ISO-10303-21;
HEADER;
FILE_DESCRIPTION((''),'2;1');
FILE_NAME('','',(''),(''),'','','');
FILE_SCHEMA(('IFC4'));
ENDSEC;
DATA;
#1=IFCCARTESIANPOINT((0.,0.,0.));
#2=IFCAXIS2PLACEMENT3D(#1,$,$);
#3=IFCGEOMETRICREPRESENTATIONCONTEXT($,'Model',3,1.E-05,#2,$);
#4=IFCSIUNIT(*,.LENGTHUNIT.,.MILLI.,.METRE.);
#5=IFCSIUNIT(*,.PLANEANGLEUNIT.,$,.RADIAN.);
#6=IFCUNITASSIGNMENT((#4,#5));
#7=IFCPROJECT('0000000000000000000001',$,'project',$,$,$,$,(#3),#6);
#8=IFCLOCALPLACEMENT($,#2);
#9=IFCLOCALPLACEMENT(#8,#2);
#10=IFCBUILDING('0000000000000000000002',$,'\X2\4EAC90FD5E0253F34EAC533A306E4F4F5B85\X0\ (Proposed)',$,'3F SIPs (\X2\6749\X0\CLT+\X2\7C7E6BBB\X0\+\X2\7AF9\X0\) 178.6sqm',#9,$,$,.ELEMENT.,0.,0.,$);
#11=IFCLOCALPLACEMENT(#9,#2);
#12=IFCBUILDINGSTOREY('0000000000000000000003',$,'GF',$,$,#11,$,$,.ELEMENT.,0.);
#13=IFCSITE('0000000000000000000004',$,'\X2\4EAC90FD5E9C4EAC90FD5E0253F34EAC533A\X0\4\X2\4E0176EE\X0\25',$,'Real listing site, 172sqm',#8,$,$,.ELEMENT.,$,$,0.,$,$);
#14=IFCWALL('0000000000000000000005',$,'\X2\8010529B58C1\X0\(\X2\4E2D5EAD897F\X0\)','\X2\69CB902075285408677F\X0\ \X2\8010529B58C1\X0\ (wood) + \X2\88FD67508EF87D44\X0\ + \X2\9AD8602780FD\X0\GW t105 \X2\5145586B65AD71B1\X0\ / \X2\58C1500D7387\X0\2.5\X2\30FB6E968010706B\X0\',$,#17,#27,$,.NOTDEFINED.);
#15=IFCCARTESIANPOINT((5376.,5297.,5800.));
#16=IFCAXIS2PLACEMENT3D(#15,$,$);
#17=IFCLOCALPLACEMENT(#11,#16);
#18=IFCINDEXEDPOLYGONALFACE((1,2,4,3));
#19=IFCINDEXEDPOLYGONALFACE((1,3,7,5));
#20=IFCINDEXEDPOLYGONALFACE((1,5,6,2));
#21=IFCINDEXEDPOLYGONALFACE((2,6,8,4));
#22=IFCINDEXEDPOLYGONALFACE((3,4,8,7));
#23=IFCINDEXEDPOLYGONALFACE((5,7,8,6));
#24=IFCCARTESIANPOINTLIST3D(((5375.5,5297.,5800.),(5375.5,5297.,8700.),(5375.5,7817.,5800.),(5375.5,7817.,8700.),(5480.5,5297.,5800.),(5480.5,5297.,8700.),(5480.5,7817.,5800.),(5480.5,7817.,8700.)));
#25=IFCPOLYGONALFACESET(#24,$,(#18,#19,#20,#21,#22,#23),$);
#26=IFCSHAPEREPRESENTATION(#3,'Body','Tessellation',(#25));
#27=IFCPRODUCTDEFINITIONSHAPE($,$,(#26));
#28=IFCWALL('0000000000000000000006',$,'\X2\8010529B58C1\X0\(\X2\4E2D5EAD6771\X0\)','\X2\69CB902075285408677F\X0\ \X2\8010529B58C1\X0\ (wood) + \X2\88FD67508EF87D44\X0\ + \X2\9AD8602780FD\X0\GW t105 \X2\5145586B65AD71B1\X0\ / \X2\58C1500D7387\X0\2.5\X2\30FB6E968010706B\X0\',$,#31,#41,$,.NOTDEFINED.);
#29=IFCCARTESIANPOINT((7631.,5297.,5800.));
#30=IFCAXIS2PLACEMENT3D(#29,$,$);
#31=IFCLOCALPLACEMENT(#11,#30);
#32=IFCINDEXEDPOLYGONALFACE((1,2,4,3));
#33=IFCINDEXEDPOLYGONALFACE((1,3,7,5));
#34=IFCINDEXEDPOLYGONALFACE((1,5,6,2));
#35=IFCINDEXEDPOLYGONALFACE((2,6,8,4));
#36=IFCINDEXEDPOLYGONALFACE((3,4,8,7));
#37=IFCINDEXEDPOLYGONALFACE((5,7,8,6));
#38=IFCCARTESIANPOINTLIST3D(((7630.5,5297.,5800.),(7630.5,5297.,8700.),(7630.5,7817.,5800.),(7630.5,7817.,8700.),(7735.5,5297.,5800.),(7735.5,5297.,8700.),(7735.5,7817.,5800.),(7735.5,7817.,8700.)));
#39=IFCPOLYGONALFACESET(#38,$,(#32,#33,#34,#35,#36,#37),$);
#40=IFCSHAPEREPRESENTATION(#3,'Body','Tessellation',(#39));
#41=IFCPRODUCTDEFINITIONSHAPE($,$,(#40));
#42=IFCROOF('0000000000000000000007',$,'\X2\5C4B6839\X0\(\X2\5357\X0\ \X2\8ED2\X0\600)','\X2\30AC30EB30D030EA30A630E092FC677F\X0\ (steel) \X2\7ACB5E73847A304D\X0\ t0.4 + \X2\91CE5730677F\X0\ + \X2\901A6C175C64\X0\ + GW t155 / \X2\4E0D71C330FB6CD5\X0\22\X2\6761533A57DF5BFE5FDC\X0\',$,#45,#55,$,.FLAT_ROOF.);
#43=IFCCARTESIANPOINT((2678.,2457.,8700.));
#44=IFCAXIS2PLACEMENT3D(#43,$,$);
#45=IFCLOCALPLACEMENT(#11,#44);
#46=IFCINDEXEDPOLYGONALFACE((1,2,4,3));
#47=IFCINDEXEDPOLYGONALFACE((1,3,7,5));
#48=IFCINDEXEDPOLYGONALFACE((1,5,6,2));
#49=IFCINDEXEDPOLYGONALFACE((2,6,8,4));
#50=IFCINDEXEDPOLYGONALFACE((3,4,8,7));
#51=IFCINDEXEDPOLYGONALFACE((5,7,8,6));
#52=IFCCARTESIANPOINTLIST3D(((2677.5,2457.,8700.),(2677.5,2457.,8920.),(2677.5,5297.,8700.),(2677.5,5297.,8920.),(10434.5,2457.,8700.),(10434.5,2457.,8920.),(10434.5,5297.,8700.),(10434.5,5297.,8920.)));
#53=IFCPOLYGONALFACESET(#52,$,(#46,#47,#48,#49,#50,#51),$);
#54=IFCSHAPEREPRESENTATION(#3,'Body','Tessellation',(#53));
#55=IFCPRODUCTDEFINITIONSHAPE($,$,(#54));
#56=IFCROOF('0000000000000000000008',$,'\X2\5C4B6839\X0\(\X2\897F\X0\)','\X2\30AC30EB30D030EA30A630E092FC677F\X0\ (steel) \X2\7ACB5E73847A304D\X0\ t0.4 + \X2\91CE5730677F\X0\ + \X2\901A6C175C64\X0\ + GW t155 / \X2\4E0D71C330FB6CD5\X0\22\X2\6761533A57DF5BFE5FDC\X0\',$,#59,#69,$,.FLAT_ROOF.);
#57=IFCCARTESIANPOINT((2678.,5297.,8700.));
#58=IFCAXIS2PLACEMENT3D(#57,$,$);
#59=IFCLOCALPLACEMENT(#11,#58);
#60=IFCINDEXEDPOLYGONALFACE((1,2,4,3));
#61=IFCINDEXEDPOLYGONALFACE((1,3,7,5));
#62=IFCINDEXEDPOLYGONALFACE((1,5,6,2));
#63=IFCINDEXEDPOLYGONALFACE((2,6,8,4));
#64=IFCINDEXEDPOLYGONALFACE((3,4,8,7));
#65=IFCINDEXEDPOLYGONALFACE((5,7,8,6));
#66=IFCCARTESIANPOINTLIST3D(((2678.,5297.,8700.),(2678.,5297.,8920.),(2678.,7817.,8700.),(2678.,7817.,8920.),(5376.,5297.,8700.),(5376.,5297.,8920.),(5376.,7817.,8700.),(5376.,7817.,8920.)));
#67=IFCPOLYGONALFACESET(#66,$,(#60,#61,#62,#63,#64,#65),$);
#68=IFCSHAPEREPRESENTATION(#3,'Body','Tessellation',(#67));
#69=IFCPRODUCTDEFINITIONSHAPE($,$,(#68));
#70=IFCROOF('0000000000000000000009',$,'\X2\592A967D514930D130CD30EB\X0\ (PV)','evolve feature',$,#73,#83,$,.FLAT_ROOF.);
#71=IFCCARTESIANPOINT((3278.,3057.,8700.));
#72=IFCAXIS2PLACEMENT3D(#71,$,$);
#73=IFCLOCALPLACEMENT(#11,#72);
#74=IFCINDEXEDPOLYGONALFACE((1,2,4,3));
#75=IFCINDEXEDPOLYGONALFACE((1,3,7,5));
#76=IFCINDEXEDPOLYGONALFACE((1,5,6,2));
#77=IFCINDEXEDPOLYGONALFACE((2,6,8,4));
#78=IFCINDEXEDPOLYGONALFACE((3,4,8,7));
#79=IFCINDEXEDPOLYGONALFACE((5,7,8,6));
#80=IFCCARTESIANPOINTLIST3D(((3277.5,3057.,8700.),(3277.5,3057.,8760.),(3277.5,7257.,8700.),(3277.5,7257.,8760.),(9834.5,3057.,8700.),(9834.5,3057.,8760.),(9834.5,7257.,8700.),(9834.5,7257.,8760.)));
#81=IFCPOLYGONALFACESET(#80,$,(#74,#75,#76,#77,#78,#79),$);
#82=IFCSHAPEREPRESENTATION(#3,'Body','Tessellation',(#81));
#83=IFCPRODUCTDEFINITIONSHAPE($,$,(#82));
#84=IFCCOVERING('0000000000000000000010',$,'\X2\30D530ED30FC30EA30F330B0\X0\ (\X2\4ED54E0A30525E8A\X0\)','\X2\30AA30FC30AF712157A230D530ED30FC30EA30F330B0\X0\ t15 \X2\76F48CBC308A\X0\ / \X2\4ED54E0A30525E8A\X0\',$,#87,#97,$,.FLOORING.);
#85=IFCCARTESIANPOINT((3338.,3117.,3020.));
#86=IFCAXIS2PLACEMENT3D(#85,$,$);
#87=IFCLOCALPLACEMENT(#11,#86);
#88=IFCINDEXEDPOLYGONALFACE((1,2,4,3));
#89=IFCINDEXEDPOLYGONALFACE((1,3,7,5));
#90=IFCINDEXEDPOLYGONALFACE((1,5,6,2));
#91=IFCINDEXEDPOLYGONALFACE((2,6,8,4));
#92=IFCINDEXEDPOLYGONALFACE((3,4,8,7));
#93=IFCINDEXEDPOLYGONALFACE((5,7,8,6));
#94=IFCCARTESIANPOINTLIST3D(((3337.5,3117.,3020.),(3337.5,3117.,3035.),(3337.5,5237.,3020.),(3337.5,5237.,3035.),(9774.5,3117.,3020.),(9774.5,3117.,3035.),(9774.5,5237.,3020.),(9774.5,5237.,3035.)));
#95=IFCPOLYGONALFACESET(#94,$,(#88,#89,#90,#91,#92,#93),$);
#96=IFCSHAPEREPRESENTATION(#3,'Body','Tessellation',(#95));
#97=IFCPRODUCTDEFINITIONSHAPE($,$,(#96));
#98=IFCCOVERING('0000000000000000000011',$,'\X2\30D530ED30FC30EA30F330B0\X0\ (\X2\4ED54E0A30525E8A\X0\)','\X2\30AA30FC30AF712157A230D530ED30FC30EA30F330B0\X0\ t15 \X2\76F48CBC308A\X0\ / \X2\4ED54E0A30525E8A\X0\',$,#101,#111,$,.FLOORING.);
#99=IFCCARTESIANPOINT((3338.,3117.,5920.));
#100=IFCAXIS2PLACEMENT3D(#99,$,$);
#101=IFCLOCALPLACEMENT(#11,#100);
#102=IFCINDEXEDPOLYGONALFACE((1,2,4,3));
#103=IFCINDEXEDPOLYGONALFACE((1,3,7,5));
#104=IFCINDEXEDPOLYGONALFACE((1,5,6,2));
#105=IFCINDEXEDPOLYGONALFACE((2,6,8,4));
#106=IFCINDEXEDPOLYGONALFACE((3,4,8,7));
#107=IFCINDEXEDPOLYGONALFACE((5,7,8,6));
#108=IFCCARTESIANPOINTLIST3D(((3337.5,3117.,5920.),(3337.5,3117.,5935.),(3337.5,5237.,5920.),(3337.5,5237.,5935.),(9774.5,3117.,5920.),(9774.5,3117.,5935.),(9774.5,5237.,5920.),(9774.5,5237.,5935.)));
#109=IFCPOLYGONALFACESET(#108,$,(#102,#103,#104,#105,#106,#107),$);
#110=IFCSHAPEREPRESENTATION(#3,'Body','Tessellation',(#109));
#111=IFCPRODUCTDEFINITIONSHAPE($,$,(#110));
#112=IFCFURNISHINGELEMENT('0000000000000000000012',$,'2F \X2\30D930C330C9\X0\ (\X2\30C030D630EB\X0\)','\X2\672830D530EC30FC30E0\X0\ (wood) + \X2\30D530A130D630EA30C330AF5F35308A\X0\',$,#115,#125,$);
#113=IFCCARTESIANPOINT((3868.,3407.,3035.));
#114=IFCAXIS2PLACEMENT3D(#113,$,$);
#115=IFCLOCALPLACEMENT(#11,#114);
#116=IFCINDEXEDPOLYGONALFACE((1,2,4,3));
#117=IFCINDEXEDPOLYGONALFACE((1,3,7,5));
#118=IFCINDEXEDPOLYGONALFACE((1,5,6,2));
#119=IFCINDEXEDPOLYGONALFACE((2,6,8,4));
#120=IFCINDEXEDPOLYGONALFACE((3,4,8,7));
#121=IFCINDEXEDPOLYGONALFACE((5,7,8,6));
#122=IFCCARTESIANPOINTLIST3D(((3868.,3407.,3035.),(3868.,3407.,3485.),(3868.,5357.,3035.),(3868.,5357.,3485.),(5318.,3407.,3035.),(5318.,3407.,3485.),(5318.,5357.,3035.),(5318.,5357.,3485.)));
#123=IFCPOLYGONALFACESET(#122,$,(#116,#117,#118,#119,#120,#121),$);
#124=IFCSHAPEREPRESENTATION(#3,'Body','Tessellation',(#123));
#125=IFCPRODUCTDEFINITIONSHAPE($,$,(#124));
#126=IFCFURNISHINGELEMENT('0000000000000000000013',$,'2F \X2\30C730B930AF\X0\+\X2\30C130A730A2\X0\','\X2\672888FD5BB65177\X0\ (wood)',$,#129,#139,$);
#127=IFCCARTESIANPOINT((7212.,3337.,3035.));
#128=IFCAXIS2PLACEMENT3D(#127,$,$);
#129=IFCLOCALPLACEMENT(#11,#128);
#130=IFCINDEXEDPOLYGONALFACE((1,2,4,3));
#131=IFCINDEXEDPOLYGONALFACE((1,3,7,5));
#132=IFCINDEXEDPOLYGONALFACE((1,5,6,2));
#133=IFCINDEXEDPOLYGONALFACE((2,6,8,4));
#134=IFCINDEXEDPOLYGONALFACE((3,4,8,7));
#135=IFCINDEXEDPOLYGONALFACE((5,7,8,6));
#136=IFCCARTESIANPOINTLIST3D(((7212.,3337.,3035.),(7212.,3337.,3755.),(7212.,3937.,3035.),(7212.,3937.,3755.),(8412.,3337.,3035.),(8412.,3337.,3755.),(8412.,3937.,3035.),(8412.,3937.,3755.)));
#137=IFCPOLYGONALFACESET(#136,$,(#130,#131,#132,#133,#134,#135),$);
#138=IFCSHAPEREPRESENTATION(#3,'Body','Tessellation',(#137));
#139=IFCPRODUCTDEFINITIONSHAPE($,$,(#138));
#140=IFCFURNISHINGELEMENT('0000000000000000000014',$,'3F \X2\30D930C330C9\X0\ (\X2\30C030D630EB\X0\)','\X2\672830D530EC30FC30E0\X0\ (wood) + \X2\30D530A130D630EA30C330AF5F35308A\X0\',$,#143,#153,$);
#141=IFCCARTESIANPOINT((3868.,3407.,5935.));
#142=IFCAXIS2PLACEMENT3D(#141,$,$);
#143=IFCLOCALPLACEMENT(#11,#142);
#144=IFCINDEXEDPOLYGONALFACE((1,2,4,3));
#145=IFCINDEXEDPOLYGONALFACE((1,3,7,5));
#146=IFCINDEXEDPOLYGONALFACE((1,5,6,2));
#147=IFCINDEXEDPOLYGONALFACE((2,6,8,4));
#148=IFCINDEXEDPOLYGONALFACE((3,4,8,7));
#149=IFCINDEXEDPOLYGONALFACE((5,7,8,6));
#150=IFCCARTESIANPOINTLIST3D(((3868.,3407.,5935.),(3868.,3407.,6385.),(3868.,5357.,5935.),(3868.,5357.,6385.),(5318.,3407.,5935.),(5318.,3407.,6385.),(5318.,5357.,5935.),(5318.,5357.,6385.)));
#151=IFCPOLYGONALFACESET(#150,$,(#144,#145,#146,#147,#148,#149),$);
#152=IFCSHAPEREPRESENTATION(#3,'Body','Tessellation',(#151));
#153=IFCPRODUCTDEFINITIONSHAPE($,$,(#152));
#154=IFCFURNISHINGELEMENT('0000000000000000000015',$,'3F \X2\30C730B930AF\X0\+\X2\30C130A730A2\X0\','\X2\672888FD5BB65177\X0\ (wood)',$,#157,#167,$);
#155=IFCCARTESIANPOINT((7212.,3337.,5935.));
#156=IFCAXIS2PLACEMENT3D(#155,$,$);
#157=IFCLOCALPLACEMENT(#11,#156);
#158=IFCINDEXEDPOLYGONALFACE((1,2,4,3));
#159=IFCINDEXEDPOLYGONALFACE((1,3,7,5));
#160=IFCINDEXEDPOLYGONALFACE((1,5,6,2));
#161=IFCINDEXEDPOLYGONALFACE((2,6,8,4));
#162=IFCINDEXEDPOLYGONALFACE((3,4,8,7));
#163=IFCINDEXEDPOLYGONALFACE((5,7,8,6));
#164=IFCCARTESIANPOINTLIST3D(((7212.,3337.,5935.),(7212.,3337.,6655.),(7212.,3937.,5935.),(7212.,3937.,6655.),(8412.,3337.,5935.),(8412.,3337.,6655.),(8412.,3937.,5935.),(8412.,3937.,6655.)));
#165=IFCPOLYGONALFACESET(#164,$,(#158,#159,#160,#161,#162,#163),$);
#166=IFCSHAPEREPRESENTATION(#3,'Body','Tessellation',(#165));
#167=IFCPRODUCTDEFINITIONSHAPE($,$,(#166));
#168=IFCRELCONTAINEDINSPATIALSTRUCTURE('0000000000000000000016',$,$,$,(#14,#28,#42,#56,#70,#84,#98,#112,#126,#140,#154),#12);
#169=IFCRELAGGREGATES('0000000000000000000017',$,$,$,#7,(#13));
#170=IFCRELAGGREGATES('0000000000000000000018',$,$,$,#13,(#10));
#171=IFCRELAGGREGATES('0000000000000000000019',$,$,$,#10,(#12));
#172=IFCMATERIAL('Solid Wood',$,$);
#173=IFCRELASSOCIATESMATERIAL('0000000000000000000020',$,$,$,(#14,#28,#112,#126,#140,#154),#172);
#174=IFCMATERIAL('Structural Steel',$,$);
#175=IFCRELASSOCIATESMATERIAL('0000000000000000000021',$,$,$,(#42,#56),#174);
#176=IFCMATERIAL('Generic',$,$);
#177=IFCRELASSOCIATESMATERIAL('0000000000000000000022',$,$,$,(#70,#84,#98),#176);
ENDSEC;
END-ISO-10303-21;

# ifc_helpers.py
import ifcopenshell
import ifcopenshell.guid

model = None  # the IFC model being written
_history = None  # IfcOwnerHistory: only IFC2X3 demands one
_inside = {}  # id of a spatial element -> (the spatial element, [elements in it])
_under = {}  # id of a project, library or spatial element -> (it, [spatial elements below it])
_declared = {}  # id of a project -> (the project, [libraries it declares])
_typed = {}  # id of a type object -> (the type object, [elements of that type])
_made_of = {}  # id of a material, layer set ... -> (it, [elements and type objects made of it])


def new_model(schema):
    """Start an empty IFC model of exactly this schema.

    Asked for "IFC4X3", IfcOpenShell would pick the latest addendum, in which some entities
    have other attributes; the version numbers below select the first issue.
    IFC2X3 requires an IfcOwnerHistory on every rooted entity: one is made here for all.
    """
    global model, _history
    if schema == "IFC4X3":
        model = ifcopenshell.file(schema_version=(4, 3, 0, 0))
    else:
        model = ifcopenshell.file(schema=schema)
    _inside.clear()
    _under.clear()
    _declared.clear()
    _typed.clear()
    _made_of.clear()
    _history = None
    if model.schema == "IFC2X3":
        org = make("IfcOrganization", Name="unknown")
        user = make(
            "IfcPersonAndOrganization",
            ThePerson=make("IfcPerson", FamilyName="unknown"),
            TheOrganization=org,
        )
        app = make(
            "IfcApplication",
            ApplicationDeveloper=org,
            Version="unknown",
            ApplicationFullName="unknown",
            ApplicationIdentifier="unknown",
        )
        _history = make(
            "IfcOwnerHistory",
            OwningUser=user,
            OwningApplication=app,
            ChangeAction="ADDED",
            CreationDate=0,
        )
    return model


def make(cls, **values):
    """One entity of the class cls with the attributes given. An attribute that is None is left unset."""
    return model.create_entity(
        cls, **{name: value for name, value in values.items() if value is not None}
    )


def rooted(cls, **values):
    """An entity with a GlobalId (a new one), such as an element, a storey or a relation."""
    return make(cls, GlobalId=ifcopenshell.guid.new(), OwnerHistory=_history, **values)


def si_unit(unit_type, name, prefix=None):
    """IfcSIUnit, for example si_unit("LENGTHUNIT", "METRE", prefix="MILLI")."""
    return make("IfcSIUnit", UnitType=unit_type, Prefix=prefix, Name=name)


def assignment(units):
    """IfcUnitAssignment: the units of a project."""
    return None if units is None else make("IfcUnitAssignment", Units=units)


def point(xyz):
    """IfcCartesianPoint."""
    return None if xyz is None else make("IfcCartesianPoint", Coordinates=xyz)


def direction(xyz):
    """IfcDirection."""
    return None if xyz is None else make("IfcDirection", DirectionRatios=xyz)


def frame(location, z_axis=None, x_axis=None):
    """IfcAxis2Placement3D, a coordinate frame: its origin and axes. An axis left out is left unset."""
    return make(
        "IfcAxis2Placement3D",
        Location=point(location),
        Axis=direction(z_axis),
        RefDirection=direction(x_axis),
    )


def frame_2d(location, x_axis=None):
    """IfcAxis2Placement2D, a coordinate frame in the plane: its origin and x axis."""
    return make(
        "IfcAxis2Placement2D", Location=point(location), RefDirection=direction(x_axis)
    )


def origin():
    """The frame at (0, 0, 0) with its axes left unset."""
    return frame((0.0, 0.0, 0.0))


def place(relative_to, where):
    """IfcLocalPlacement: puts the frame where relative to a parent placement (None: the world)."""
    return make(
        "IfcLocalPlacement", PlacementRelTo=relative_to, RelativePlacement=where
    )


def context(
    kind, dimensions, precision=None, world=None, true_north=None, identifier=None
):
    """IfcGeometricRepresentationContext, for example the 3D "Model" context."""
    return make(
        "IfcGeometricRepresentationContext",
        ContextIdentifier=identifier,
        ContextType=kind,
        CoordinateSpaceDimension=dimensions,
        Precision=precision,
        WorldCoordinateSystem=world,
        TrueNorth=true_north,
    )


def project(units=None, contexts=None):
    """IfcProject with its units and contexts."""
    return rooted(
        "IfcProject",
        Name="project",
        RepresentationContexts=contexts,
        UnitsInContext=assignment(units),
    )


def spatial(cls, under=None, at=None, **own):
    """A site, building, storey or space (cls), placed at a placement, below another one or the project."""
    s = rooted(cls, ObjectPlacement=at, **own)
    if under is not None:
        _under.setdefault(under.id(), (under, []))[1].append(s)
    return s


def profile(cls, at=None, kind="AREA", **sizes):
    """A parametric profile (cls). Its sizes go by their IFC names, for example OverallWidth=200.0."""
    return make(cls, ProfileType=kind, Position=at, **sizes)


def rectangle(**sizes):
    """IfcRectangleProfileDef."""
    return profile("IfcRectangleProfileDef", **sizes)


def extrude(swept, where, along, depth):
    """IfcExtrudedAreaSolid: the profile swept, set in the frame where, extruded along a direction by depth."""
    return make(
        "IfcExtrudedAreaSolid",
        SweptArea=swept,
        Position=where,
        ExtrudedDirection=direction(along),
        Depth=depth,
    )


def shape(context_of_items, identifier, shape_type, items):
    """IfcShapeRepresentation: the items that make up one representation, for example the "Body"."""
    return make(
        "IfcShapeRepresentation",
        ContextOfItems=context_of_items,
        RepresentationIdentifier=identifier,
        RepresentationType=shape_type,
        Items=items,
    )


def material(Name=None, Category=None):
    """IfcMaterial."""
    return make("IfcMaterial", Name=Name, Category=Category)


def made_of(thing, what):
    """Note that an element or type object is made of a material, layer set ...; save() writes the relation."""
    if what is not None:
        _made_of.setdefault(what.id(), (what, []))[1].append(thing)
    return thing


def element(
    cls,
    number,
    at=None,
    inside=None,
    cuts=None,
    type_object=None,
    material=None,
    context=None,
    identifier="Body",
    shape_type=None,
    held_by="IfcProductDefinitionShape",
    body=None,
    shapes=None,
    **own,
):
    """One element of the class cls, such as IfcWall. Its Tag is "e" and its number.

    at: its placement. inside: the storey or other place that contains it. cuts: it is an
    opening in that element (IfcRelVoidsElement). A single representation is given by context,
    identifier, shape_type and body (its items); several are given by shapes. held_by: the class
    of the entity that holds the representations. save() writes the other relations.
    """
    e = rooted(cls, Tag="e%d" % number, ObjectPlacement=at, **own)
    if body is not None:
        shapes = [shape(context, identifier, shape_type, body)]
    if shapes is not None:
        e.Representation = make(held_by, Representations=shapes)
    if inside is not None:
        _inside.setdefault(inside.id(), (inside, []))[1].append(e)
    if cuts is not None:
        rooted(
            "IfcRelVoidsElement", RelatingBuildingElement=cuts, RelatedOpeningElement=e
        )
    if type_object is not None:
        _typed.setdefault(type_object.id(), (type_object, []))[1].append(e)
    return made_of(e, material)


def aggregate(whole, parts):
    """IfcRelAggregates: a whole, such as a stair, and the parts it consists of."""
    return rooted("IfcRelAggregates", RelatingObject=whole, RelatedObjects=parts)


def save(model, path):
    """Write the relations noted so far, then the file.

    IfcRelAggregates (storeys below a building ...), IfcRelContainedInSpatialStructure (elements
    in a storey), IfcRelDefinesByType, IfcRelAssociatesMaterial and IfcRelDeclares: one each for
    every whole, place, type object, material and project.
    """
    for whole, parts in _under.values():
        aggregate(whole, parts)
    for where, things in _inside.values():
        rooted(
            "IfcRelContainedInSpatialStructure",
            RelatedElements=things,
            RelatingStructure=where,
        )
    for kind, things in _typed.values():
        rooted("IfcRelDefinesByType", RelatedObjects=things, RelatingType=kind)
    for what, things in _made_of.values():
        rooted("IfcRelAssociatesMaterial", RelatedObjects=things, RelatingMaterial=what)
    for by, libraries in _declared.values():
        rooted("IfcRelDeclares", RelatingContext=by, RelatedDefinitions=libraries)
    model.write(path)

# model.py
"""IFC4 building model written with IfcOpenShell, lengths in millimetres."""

from ifc_helpers import new_model, si_unit, frame, frame_2d, origin, place, context, project, spatial, rectangle, extrude, material, element, save


model = new_model("IFC4")

# Units and contexts
model_context = context("Model", 3, precision=1e-05, world=origin())
ifc_project = project(units=[si_unit("LENGTHUNIT", "METRE", prefix="MILLI"), si_unit("PLANEANGLEUNIT", "RADIAN")], contexts=[model_context])

# Site, building, storey
site_placement = place(None, origin())
site = spatial("IfcSite", under=ifc_project, at=site_placement, Name="京都府京都市右京区4丁目25", ObjectType="Real listing site, 172sqm", CompositionType="ELEMENT", RefElevation=0.0)
building_placement = place(site_placement, origin())
building = spatial("IfcBuilding", under=site, at=building_placement, Name="京都市右京区の住宅 (Proposed)", ObjectType="3F SIPs (杉CLT+籾殻+竹) 178.6sqm", CompositionType="ELEMENT", ElevationOfRefHeight=0.0, ElevationOfTerrain=0.0)
storey_placement = place(building_placement, origin())
storey = spatial("IfcBuildingStorey", under=building, at=storey_placement, Name="GF", CompositionType="ELEMENT", Elevation=0.0)

# Shared definitions
ifc_material_1 = material(Name="Solid Wood")

# Walls
wall_1_placement = place(storey_placement, frame((5376.0, 5297.0, 5800.0)))
element("IfcWall", 1, at=wall_1_placement, inside=storey, material=ifc_material_1, Name="耐力壁(中庭西)", Description="構造用合板 耐力壁 (wood) + 製材軸組 + 高性能GW t105 充填断熱 / 壁倍率2.5・準耐火", PredefinedType="NOTDEFINED", context=model_context, shape_type="SweptSolid", body=[
    extrude(rectangle(XDim=105.0, YDim=2520.0, at=frame_2d((52.0, 1260.0))), frame((5376.0, 5297.0, 5800.0)), (0.0, 0.0, 1.0), 2900.0),
])
wall_2_placement = place(storey_placement, frame((7631.0, 5297.0, 5800.0)))
element("IfcWall", 2, at=wall_2_placement, inside=storey, material=ifc_material_1, Name="耐力壁(中庭東)", Description="構造用合板 耐力壁 (wood) + 製材軸組 + 高性能GW t105 充填断熱 / 壁倍率2.5・準耐火", PredefinedType="NOTDEFINED", context=model_context, shape_type="SweptSolid", body=[
    extrude(rectangle(XDim=105.0, YDim=2520.0, at=frame_2d((52.0, 1260.0))), frame((7631.0, 5297.0, 5800.0)), (0.0, 0.0, 1.0), 2900.0),
])

# Roofs
ifc_material_2 = material(Name="Structural Steel")
roof_1_placement = place(storey_placement, frame((2678.0, 2457.0, 8700.0)))
element("IfcRoof", 3, at=roof_1_placement, inside=storey, material=ifc_material_2, Name="屋根(南 軒600)", Description="ガルバリウム鋼板 (steel) 立平葺き t0.4 + 野地板 + 通気層 + GW t155 / 不燃・法22条区域対応", PredefinedType="FLAT_ROOF", context=model_context, shape_type="SweptSolid", body=[
    extrude(rectangle(XDim=7757.0, YDim=2840.0, at=frame_2d((3878.0, 1420.0))), frame((2678.0, 2457.0, 8700.0)), (0.0, 0.0, 1.0), 220.0),
])
roof_2_placement = place(storey_placement, frame((2678.0, 5297.0, 8700.0)))
element("IfcRoof", 4, at=roof_2_placement, inside=storey, material=ifc_material_2, Name="屋根(西)", Description="ガルバリウム鋼板 (steel) 立平葺き t0.4 + 野地板 + 通気層 + GW t155 / 不燃・法22条区域対応", PredefinedType="FLAT_ROOF", context=model_context, shape_type="SweptSolid", body=[
    extrude(rectangle(XDim=2698.0, YDim=2520.0, at=frame_2d((1349.0, 1260.0))), frame((2678.0, 5297.0, 8700.0)), (0.0, 0.0, 1.0), 220.0),
])
ifc_material_3 = material(Name="Generic")
roof_3_placement = place(storey_placement, frame((3278.0, 3057.0, 8700.0)))
element("IfcRoof", 5, at=roof_3_placement, inside=storey, material=ifc_material_3, Name="太陽光パネル (PV)", Description="evolve feature", PredefinedType="FLAT_ROOF", context=model_context, shape_type="SweptSolid", body=[
    extrude(rectangle(XDim=6557.0, YDim=4200.0, at=frame_2d((3278.0, 2100.0))), frame((3278.0, 3057.0, 8700.0)), (0.0, 0.0, 1.0), 60.0),
])

# Coverings
covering_1_placement = place(storey_placement, frame((3338.0, 3117.0, 3020.0)))
element("IfcCovering", 6, at=covering_1_placement, inside=storey, material=ifc_material_3, Name="フローリング (仕上げ床)", Description="オーク無垢フローリング t15 直貼り / 仕上げ床", PredefinedType="FLOORING", context=model_context, shape_type="SweptSolid", body=[
    extrude(rectangle(XDim=6437.0, YDim=2120.0, at=frame_2d((3218.0, 1060.0))), frame((3338.0, 3117.0, 3020.0)), (0.0, 0.0, 1.0), 15.0),
])
covering_2_placement = place(storey_placement, frame((3338.0, 3117.0, 5920.0)))
element("IfcCovering", 7, at=covering_2_placement, inside=storey, material=ifc_material_3, Name="フローリング (仕上げ床)", Description="オーク無垢フローリング t15 直貼り / 仕上げ床", PredefinedType="FLOORING", context=model_context, shape_type="SweptSolid", body=[
    extrude(rectangle(XDim=6437.0, YDim=2120.0, at=frame_2d((3218.0, 1060.0))), frame((3338.0, 3117.0, 5920.0)), (0.0, 0.0, 1.0), 15.0),
])

# Furnishing elements
furnishing_1_placement = place(storey_placement, frame((3868.0, 3407.0, 3035.0)))
element("IfcFurnishingElement", 8, at=furnishing_1_placement, inside=storey, material=ifc_material_1, Name="2F ベッド (ダブル)", Description="木フレーム (wood) + ファブリック張り", context=model_context, shape_type="SweptSolid", body=[
    extrude(rectangle(XDim=1450.0, YDim=1950.0, at=frame_2d((725.0, 975.0))), frame((3868.0, 3407.0, 3035.0)), (0.0, 0.0, 1.0), 450.0),
])
furnishing_2_placement = place(storey_placement, frame((7212.0, 3337.0, 3035.0)))
element("IfcFurnishingElement", 9, at=furnishing_2_placement, inside=storey, material=ifc_material_1, Name="2F デスク+チェア", Description="木製家具 (wood)", context=model_context, shape_type="SweptSolid", body=[
    extrude(rectangle(XDim=1200.0, YDim=600.0, at=frame_2d((600.0, 300.0))), frame((7212.0, 3337.0, 3035.0)), (0.0, 0.0, 1.0), 720.0),
])
furnishing_3_placement = place(storey_placement, frame((3868.0, 3407.0, 5935.0)))
element("IfcFurnishingElement", 10, at=furnishing_3_placement, inside=storey, material=ifc_material_1, Name="3F ベッド (ダブル)", Description="木フレーム (wood) + ファブリック張り", context=model_context, shape_type="SweptSolid", body=[
    extrude(rectangle(XDim=1450.0, YDim=1950.0, at=frame_2d((725.0, 975.0))), frame((3868.0, 3407.0, 5935.0)), (0.0, 0.0, 1.0), 450.0),
])
furnishing_4_placement = place(storey_placement, frame((7212.0, 3337.0, 5935.0)))
element("IfcFurnishingElement", 11, at=furnishing_4_placement, inside=storey, material=ifc_material_1, Name="3F デスク+チェア", Description="木製家具 (wood)", context=model_context, shape_type="SweptSolid", body=[
    extrude(rectangle(XDim=1200.0, YDim=600.0, at=frame_2d((600.0, 300.0))), frame((7212.0, 3337.0, 5935.0)), (0.0, 0.0, 1.0), 720.0),
])

save(model, "model.ifc")
